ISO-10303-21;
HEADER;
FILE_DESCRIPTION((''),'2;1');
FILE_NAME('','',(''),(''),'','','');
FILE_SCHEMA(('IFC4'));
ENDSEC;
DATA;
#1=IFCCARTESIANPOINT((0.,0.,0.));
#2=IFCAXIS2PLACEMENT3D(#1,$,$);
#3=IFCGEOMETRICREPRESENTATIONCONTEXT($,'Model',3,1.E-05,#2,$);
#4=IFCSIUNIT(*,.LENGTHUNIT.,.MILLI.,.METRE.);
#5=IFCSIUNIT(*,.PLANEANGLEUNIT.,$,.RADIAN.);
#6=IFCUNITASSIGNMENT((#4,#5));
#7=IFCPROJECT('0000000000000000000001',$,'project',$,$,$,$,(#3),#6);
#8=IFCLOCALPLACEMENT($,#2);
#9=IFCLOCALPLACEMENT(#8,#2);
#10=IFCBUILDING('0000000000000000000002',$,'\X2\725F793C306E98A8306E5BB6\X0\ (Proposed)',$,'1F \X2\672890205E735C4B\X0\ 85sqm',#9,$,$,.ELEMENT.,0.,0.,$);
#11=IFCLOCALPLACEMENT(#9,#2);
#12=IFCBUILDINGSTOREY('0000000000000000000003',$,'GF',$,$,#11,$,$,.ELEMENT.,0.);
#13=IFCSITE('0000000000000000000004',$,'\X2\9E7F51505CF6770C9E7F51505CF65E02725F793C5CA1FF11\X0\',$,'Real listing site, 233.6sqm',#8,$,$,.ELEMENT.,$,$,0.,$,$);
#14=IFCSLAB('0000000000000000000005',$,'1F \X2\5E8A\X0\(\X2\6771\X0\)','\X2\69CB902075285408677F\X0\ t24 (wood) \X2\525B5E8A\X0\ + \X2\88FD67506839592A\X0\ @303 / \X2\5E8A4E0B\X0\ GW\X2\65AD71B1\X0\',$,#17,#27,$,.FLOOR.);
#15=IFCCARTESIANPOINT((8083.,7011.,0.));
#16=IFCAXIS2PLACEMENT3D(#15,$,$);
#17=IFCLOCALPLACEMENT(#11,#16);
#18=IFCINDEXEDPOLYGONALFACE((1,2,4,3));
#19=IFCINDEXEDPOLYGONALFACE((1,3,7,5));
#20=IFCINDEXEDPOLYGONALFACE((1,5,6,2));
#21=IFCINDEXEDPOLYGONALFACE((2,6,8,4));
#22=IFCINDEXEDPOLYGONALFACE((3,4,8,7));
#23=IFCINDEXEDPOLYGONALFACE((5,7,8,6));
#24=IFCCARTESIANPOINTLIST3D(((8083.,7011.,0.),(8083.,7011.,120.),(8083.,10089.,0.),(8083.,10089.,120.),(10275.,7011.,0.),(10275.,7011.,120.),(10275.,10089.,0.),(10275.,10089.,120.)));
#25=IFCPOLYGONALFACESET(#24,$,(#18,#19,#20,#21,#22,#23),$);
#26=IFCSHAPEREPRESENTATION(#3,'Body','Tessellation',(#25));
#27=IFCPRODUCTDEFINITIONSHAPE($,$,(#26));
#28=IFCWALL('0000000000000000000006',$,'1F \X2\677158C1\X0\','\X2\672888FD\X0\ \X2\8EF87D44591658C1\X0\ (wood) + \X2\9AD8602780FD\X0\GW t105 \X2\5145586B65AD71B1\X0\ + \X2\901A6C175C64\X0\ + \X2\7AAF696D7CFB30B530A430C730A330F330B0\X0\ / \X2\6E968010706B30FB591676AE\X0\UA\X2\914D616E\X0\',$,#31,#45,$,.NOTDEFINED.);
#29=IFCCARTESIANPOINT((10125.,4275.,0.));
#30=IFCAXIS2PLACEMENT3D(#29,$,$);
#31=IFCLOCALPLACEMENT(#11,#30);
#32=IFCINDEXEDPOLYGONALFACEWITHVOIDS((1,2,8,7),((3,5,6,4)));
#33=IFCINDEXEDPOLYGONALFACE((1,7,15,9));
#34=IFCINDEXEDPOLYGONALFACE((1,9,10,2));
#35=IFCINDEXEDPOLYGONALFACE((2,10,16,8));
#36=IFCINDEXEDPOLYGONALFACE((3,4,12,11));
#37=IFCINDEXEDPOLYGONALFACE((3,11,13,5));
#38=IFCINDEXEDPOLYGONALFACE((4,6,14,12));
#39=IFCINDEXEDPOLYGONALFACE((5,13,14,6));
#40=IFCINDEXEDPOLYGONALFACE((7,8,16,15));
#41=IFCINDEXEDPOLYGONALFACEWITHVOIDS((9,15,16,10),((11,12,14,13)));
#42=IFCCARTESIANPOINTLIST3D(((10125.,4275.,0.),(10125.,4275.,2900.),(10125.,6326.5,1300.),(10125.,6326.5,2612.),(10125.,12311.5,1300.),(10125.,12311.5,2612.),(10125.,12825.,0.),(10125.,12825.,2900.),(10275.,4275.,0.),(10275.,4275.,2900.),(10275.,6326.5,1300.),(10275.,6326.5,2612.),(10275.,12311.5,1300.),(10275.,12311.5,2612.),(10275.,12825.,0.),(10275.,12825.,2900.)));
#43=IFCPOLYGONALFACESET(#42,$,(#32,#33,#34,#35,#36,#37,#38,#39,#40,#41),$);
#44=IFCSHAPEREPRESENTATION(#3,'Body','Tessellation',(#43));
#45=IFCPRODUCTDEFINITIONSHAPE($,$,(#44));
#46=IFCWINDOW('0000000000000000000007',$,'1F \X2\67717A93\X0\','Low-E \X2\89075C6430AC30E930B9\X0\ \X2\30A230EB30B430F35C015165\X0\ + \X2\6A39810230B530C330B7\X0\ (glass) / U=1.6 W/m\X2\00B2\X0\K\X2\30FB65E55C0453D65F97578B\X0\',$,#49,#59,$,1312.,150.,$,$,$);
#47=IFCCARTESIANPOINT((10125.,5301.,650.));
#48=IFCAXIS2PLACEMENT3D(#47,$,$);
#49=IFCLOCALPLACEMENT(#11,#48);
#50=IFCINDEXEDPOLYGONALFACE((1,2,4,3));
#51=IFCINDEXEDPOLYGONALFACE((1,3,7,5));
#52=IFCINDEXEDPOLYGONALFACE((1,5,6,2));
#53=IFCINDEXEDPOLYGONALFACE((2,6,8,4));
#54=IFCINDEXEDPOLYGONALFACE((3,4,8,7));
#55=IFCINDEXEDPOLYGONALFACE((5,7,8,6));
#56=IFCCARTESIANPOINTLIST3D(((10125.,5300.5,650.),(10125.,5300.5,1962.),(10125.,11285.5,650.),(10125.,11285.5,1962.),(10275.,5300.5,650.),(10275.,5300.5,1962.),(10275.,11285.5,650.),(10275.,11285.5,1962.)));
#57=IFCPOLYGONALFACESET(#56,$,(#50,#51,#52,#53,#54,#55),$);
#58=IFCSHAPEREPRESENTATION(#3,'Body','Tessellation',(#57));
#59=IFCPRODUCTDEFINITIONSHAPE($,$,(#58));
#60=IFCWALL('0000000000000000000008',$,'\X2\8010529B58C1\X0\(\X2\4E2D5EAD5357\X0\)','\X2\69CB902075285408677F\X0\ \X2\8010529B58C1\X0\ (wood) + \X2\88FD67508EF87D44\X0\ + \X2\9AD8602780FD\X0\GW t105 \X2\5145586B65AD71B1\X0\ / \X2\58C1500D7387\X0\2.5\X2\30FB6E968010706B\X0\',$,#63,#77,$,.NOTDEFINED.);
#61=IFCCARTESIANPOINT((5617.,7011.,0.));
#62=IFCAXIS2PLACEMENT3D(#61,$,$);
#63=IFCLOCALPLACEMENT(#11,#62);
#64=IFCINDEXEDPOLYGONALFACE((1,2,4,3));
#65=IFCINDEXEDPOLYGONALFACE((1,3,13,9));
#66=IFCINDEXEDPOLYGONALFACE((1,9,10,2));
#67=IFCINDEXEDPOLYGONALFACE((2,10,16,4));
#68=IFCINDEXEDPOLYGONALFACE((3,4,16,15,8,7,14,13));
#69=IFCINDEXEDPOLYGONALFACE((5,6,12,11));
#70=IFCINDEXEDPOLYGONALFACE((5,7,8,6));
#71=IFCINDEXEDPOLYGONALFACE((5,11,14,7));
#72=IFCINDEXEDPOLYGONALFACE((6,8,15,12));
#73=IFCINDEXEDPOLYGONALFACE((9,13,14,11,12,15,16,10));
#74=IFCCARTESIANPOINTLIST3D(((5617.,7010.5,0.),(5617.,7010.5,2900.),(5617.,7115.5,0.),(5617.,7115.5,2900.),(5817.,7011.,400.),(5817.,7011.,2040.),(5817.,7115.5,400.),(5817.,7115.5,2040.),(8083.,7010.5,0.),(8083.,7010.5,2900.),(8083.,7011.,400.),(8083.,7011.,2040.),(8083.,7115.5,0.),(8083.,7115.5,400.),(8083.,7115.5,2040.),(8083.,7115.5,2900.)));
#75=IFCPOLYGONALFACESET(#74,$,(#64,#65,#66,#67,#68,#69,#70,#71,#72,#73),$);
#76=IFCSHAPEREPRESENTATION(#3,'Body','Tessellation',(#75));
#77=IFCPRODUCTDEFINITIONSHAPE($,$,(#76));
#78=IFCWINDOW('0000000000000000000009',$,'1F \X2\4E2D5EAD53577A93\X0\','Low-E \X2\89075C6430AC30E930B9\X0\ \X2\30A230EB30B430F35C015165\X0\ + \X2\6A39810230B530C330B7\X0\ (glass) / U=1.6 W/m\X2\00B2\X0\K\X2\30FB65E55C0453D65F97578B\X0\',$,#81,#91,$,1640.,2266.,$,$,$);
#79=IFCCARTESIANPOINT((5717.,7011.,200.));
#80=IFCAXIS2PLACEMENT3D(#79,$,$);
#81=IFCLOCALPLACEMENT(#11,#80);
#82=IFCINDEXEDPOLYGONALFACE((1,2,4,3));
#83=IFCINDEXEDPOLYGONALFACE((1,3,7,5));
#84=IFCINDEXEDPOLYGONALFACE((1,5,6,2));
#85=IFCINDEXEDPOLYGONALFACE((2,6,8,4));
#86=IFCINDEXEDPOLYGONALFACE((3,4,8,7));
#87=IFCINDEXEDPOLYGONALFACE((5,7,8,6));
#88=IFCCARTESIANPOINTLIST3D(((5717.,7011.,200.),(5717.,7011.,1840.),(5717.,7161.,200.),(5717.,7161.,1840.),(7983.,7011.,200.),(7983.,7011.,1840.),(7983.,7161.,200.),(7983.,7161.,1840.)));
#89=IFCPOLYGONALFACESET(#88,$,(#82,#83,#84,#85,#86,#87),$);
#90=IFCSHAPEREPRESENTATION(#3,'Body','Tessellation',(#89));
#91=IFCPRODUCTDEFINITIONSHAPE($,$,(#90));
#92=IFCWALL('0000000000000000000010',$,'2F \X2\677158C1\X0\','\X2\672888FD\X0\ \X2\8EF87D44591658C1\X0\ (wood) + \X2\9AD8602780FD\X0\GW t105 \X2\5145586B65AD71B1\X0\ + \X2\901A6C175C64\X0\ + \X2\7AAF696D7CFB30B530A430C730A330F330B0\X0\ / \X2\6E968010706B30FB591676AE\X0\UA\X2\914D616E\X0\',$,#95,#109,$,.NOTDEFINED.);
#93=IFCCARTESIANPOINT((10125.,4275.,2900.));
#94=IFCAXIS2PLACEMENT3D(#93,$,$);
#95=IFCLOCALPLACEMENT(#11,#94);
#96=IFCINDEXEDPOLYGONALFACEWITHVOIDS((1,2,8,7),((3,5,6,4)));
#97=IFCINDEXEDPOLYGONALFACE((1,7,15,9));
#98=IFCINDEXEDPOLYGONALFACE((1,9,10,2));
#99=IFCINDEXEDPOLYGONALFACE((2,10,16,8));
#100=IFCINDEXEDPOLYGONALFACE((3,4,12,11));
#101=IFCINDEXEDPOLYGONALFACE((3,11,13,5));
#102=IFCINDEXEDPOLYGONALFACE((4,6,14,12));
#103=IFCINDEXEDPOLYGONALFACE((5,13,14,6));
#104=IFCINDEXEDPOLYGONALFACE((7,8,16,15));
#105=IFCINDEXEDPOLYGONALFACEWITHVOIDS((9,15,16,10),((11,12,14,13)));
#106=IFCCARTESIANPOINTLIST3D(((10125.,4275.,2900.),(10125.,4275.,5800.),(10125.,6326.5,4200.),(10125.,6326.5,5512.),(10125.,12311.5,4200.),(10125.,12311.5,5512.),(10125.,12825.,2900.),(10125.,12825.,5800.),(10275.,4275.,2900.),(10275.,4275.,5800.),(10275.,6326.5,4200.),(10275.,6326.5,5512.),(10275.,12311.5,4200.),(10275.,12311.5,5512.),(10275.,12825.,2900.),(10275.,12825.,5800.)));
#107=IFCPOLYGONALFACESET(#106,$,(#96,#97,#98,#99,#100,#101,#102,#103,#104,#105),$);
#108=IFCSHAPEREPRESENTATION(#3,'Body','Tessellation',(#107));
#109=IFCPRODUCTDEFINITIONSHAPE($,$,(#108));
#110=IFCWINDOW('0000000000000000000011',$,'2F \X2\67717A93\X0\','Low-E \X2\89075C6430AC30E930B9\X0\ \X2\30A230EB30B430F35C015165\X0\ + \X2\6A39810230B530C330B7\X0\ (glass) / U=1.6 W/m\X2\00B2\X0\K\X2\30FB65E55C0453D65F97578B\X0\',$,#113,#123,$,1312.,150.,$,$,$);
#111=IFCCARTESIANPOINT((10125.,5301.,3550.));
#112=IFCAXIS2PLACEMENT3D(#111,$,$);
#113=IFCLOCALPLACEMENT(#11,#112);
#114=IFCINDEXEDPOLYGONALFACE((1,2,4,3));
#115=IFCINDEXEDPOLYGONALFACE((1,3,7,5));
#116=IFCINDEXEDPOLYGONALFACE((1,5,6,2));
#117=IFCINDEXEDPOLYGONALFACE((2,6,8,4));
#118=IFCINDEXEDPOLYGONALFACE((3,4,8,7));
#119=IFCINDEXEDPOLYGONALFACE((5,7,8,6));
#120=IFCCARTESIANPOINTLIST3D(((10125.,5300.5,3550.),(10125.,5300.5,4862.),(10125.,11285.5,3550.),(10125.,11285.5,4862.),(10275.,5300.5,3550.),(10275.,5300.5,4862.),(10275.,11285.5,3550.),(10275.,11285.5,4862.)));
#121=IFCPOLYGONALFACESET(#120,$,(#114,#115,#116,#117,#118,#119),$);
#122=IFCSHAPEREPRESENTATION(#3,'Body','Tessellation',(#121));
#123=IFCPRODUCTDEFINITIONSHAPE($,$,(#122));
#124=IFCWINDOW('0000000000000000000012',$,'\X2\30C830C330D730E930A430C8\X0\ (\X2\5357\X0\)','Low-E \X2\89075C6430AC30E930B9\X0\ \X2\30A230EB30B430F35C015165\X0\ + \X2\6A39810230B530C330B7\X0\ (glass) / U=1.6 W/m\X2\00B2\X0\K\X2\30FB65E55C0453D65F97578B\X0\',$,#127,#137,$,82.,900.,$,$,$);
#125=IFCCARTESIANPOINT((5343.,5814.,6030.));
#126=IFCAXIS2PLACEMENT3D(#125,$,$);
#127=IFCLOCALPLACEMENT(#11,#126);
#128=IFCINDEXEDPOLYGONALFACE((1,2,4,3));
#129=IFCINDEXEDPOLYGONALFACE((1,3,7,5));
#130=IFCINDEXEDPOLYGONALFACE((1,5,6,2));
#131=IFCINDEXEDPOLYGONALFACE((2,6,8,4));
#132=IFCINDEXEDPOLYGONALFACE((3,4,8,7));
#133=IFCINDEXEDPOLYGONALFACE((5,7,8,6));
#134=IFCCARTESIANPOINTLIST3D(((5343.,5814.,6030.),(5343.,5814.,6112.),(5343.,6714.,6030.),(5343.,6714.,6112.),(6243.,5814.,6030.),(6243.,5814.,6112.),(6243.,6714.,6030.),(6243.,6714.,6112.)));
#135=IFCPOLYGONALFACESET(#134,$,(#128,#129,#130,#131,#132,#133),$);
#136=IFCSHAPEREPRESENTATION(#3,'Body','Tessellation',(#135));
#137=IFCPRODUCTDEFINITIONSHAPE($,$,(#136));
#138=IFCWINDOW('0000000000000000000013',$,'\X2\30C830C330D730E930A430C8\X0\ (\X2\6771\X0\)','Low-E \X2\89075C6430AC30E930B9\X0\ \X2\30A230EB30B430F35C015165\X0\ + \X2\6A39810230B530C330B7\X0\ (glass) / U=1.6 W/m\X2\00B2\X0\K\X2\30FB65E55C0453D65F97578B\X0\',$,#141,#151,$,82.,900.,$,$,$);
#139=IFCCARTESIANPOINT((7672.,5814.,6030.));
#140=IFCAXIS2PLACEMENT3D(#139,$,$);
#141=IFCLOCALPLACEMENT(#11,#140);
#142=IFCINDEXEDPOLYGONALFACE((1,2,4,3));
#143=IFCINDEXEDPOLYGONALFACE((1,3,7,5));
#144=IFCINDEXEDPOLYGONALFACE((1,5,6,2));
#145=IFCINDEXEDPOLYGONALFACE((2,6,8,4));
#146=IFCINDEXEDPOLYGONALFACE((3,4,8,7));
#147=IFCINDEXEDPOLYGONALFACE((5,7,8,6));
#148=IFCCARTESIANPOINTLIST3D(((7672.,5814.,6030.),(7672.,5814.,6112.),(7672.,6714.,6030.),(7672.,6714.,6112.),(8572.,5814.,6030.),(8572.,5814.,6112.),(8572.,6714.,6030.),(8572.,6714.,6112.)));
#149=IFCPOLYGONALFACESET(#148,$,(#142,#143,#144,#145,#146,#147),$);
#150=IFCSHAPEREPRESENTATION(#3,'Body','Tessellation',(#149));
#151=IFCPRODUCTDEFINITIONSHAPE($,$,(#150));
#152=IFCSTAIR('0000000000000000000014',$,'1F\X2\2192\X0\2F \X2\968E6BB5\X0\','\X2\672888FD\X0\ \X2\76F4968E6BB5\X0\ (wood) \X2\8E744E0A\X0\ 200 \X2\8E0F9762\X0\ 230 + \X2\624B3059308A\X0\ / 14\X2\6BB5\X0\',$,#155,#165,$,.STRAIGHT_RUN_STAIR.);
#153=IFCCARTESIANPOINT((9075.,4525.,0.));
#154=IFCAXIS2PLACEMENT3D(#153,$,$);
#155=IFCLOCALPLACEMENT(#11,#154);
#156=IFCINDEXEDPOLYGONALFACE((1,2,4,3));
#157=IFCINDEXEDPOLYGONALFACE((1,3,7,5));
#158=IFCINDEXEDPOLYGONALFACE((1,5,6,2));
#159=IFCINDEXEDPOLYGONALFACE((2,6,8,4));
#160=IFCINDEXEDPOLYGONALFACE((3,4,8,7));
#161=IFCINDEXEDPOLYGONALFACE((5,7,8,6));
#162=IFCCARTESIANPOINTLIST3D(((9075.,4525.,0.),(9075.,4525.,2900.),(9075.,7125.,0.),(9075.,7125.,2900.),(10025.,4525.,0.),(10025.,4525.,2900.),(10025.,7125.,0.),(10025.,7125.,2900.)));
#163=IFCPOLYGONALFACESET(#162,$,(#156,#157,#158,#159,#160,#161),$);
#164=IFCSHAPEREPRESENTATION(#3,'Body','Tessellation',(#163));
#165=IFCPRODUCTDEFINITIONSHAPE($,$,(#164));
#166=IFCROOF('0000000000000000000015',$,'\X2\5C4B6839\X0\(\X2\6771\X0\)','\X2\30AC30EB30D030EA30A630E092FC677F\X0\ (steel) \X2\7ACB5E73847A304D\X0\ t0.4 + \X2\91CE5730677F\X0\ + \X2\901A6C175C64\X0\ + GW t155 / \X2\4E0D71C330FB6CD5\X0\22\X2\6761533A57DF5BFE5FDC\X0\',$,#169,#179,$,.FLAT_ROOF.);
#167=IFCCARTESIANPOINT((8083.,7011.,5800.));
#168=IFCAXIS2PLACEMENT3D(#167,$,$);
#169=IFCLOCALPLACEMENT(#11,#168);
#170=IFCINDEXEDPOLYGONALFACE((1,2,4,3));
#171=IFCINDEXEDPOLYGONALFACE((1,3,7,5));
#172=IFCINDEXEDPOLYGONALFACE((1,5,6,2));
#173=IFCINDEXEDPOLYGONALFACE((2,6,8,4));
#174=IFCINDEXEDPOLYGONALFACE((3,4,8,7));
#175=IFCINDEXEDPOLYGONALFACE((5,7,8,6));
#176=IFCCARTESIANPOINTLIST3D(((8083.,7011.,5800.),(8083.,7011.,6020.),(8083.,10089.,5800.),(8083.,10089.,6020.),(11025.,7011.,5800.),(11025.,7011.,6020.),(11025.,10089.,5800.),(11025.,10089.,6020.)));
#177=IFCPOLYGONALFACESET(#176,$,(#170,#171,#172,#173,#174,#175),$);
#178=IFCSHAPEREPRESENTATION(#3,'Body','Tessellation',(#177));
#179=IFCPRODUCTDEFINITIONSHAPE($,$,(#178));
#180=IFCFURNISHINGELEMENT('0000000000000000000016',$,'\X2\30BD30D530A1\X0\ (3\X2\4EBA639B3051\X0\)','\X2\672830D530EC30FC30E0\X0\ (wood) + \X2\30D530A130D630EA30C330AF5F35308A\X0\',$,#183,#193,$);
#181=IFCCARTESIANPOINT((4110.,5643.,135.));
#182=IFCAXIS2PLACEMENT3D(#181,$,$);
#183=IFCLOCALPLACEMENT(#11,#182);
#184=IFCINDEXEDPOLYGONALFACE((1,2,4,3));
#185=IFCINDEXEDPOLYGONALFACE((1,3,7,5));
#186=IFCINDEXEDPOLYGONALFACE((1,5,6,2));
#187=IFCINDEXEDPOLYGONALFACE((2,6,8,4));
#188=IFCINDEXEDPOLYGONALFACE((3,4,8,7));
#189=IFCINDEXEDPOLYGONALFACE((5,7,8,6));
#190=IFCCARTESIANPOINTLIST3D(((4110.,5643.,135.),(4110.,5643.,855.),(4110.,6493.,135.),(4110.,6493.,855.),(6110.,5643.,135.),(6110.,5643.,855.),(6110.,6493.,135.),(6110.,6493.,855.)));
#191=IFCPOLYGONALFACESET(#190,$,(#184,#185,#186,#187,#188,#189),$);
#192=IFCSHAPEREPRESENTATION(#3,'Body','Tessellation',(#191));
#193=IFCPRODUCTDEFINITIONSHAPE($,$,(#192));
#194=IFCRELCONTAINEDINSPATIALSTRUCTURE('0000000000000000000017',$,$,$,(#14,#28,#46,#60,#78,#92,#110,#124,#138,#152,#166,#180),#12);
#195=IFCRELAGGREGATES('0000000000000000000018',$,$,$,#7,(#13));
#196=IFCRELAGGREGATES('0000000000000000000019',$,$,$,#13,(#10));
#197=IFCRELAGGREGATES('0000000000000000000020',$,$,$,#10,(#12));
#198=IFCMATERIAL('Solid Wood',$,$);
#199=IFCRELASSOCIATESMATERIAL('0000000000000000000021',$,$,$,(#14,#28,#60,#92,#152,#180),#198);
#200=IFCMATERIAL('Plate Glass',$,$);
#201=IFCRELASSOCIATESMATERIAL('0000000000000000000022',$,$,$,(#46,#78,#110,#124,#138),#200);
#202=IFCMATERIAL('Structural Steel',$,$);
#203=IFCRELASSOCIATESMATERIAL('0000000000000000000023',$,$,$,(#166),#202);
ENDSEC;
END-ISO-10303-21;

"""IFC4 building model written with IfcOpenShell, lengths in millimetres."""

from ifc_helpers import new_model, si_unit, frame, frame_2d, origin, place, context, project, spatial, rectangle, extrude, material, element, fill, save


model = new_model("IFC4")

# Units and contexts
model_context = context("Model", 3, precision=1e-05, world=origin())
ifc_project = project(units=[si_unit("LENGTHUNIT", "METRE", prefix="MILLI"), si_unit("PLANEANGLEUNIT", "RADIAN")], contexts=[model_context])

# Site, building, storey
site_placement = place(None, origin())
site = spatial("IfcSite", under=ifc_project, at=site_placement, Name="鹿児島県鹿児島市牟礼岡１", ObjectType="Real listing site, 233.6sqm", CompositionType="ELEMENT", RefElevation=0.0)
building_placement = place(site_placement, origin())
building = spatial("IfcBuilding", under=site, at=building_placement, Name="牟礼の風の家 (Proposed)", ObjectType="1F 木造平屋 85sqm", CompositionType="ELEMENT", ElevationOfRefHeight=0.0, ElevationOfTerrain=0.0)
storey_placement = place(building_placement, origin())
storey = spatial("IfcBuildingStorey", under=building, at=storey_placement, Name="GF", CompositionType="ELEMENT", Elevation=0.0)

# Slab
ifc_material_1 = material(Name="Solid Wood")
slab_placement = place(storey_placement, frame((8083.0, 7011.0, 0.0)))
element("IfcSlab", 1, at=slab_placement, inside=storey, material=ifc_material_1, Name="1F 床(東)", Description="構造用合板 t24 (wood) 剛床 + 製材根太 @303 / 床下 GW断熱", PredefinedType="FLOOR", context=model_context, shape_type="SweptSolid", body=[
    extrude(rectangle(XDim=2192.0, YDim=3078.0, at=frame_2d((1096.0, 1539.0))), frame((8083.0, 7011.0, 0.0)), (0.0, 0.0, 1.0), 120.0),
])

# Walls, openings, windows
wall_1_placement = place(storey_placement, frame((10125.0, 4275.0, 0.0)))
wall_1 = element("IfcWall", 2, at=wall_1_placement, inside=storey, material=ifc_material_1, Name="1F 東壁", Description="木製 軸組外壁 (wood) + 高性能GW t105 充填断熱 + 通気層 + 窯業系サイディング / 準耐火・外皮UA配慮", PredefinedType="NOTDEFINED", context=model_context, shape_type="SweptSolid", body=[
    extrude(rectangle(XDim=150.0, YDim=8550.0, at=frame_2d((75.0, 4275.0))), frame((10125.0, 4275.0, 0.0)), (0.0, 0.0, 1.0), 2900.0),
])
opening_1_placement = place(storey_placement, frame((10125.0, 5301.0, 650.0)))
opening_1 = element("IfcOpeningElement", 3, at=opening_1_placement, cuts=wall_1, PredefinedType="NOTDEFINED", context=model_context, shape_type="SweptSolid", body=[
    extrude(rectangle(XDim=150.0, YDim=5985.0, at=frame_2d((75.0, 2992.0))), frame((10125.0, 5301.0, 650.0)), (0.0, 0.0, 1.0), 1312.0),
])
ifc_material_2 = material(Name="Plate Glass")
window_1_placement = place(storey_placement, frame((10125.0, 5301.0, 650.0)))
window_1 = element("IfcWindow", 4, at=window_1_placement, inside=storey, material=ifc_material_2, Name="1F 東窓", Description="Low-E 複層ガラス アルゴン封入 + 樹脂サッシ (glass) / U=1.6 W/m²K・日射取得型", OverallHeight=1312.0, OverallWidth=150.0, context=model_context, shape_type="SweptSolid", body=[
    extrude(rectangle(XDim=150.0, YDim=5985.0, at=frame_2d((75.0, 2992.0))), frame((10125.0, 5301.0, 650.0)), (0.0, 0.0, 1.0), 1312.0),
])
fill(opening_1, window_1)
wall_2_placement = place(storey_placement, frame((5617.0, 7011.0, 0.0)))
wall_2 = element("IfcWall", 5, at=wall_2_placement, inside=storey, material=ifc_material_1, Name="耐力壁(中庭南)", Description="構造用合板 耐力壁 (wood) + 製材軸組 + 高性能GW t105 充填断熱 / 壁倍率2.5・準耐火", PredefinedType="NOTDEFINED", context=model_context, shape_type="SweptSolid", body=[
    extrude(rectangle(XDim=2466.0, YDim=105.0, at=frame_2d((1233.0, 52.0))), frame((5617.0, 7011.0, 0.0)), (0.0, 0.0, 1.0), 2900.0),
])
opening_2_placement = place(storey_placement, frame((5717.0, 7011.0, 200.0)))
opening_2 = element("IfcOpeningElement", 6, at=opening_2_placement, cuts=wall_2, PredefinedType="NOTDEFINED", context=model_context, shape_type="SweptSolid", body=[
    extrude(rectangle(XDim=2266.0, YDim=150.0, at=frame_2d((1133.0, 75.0))), frame((5717.0, 7011.0, 200.0)), (0.0, 0.0, 1.0), 1640.0),
])
window_2_placement = place(storey_placement, frame((5717.0, 7011.0, 200.0)))
window_2 = element("IfcWindow", 7, at=window_2_placement, inside=storey, material=ifc_material_2, Name="1F 中庭南窓", Description="Low-E 複層ガラス アルゴン封入 + 樹脂サッシ (glass) / U=1.6 W/m²K・日射取得型", OverallHeight=1640.0, OverallWidth=2266.0, context=model_context, shape_type="SweptSolid", body=[
    extrude(rectangle(XDim=2266.0, YDim=150.0, at=frame_2d((1133.0, 75.0))), frame((5717.0, 7011.0, 200.0)), (0.0, 0.0, 1.0), 1640.0),
])
fill(opening_2, window_2)

# Wall, opening, window
wall_3_placement = place(storey_placement, frame((10125.0, 4275.0, 2900.0)))
wall_3 = element("IfcWall", 8, at=wall_3_placement, inside=storey, material=ifc_material_1, Name="2F 東壁", Description="木製 軸組外壁 (wood) + 高性能GW t105 充填断熱 + 通気層 + 窯業系サイディング / 準耐火・外皮UA配慮", PredefinedType="NOTDEFINED", context=model_context, shape_type="SweptSolid", body=[
    extrude(rectangle(XDim=150.0, YDim=8550.0, at=frame_2d((75.0, 4275.0))), frame((10125.0, 4275.0, 2900.0)), (0.0, 0.0, 1.0), 2900.0),
])
opening_3_placement = place(storey_placement, frame((10125.0, 5301.0, 3550.0)))
opening_3 = element("IfcOpeningElement", 9, at=opening_3_placement, cuts=wall_3, PredefinedType="NOTDEFINED", context=model_context, shape_type="SweptSolid", body=[
    extrude(rectangle(XDim=150.0, YDim=5985.0, at=frame_2d((75.0, 2992.0))), frame((10125.0, 5301.0, 3550.0)), (0.0, 0.0, 1.0), 1312.0),
])
window_3_placement = place(storey_placement, frame((10125.0, 5301.0, 3550.0)))
window_3 = element("IfcWindow", 10, at=window_3_placement, inside=storey, material=ifc_material_2, Name="2F 東窓", Description="Low-E 複層ガラス アルゴン封入 + 樹脂サッシ (glass) / U=1.6 W/m²K・日射取得型", OverallHeight=1312.0, OverallWidth=150.0, context=model_context, shape_type="SweptSolid", body=[
    extrude(rectangle(XDim=150.0, YDim=5985.0, at=frame_2d((75.0, 2992.0))), frame((10125.0, 5301.0, 3550.0)), (0.0, 0.0, 1.0), 1312.0),
])
fill(opening_3, window_3)

# Windows
window_4_placement = place(storey_placement, frame((5343.0, 5814.0, 6030.0)))
element("IfcWindow", 11, at=window_4_placement, inside=storey, material=ifc_material_2, Name="トップライト (南)", Description="Low-E 複層ガラス アルゴン封入 + 樹脂サッシ (glass) / U=1.6 W/m²K・日射取得型", OverallHeight=82.0, OverallWidth=900.0, context=model_context, shape_type="SweptSolid", body=[
    extrude(rectangle(XDim=900.0, YDim=900.0, at=frame_2d((450.0, 450.0))), frame((5343.0, 5814.0, 6030.0)), (0.0, 0.0, 1.0), 82.0),
])
window_5_placement = place(storey_placement, frame((7672.0, 5814.0, 6030.0)))
element("IfcWindow", 12, at=window_5_placement, inside=storey, material=ifc_material_2, Name="トップライト (東)", Description="Low-E 複層ガラス アルゴン封入 + 樹脂サッシ (glass) / U=1.6 W/m²K・日射取得型", OverallHeight=82.0, OverallWidth=900.0, context=model_context, shape_type="SweptSolid", body=[
    extrude(rectangle(XDim=900.0, YDim=900.0, at=frame_2d((450.0, 450.0))), frame((7672.0, 5814.0, 6030.0)), (0.0, 0.0, 1.0), 82.0),
])

# Stair
stair_placement = place(storey_placement, frame((9075.0, 4525.0, 0.0)))
element("IfcStair", 13, at=stair_placement, inside=storey, material=ifc_material_1, Name="1F→2F 階段", Description="木製 直階段 (wood) 蹴上 200 踏面 230 + 手すり / 14段", PredefinedType="STRAIGHT_RUN_STAIR", context=model_context, shape_type="SweptSolid", body=[
    extrude(rectangle(XDim=950.0, YDim=2600.0, at=frame_2d((475.0, 1300.0))), frame((9075.0, 4525.0, 0.0)), (0.0, 0.0, 1.0), 2900.0),
])

# Roof
ifc_material_3 = material(Name="Structural Steel")
roof_placement = place(storey_placement, frame((8083.0, 7011.0, 5800.0)))
element("IfcRoof", 14, at=roof_placement, inside=storey, material=ifc_material_3, Name="屋根(東)", Description="ガルバリウム鋼板 (steel) 立平葺き t0.4 + 野地板 + 通気層 + GW t155 / 不燃・法22条区域対応", PredefinedType="FLAT_ROOF", context=model_context, shape_type="SweptSolid", body=[
    extrude(rectangle(XDim=2942.0, YDim=3078.0, at=frame_2d((1471.0, 1539.0))), frame((8083.0, 7011.0, 5800.0)), (0.0, 0.0, 1.0), 220.0),
])

# Furnishing element
furnishing_1_placement = place(storey_placement, frame((4110.0, 5643.0, 135.0)))
element("IfcFurnishingElement", 15, at=furnishing_1_placement, inside=storey, material=ifc_material_1, Name="ソファ (3人掛け)", Description="木フレーム (wood) + ファブリック張り", context=model_context, shape_type="SweptSolid", body=[
    extrude(rectangle(XDim=2000.0, YDim=850.0, at=frame_2d((1000.0, 425.0))), frame((4110.0, 5643.0, 135.0)), (0.0, 0.0, 1.0), 720.0),
])

save(model, "model.ifc")
